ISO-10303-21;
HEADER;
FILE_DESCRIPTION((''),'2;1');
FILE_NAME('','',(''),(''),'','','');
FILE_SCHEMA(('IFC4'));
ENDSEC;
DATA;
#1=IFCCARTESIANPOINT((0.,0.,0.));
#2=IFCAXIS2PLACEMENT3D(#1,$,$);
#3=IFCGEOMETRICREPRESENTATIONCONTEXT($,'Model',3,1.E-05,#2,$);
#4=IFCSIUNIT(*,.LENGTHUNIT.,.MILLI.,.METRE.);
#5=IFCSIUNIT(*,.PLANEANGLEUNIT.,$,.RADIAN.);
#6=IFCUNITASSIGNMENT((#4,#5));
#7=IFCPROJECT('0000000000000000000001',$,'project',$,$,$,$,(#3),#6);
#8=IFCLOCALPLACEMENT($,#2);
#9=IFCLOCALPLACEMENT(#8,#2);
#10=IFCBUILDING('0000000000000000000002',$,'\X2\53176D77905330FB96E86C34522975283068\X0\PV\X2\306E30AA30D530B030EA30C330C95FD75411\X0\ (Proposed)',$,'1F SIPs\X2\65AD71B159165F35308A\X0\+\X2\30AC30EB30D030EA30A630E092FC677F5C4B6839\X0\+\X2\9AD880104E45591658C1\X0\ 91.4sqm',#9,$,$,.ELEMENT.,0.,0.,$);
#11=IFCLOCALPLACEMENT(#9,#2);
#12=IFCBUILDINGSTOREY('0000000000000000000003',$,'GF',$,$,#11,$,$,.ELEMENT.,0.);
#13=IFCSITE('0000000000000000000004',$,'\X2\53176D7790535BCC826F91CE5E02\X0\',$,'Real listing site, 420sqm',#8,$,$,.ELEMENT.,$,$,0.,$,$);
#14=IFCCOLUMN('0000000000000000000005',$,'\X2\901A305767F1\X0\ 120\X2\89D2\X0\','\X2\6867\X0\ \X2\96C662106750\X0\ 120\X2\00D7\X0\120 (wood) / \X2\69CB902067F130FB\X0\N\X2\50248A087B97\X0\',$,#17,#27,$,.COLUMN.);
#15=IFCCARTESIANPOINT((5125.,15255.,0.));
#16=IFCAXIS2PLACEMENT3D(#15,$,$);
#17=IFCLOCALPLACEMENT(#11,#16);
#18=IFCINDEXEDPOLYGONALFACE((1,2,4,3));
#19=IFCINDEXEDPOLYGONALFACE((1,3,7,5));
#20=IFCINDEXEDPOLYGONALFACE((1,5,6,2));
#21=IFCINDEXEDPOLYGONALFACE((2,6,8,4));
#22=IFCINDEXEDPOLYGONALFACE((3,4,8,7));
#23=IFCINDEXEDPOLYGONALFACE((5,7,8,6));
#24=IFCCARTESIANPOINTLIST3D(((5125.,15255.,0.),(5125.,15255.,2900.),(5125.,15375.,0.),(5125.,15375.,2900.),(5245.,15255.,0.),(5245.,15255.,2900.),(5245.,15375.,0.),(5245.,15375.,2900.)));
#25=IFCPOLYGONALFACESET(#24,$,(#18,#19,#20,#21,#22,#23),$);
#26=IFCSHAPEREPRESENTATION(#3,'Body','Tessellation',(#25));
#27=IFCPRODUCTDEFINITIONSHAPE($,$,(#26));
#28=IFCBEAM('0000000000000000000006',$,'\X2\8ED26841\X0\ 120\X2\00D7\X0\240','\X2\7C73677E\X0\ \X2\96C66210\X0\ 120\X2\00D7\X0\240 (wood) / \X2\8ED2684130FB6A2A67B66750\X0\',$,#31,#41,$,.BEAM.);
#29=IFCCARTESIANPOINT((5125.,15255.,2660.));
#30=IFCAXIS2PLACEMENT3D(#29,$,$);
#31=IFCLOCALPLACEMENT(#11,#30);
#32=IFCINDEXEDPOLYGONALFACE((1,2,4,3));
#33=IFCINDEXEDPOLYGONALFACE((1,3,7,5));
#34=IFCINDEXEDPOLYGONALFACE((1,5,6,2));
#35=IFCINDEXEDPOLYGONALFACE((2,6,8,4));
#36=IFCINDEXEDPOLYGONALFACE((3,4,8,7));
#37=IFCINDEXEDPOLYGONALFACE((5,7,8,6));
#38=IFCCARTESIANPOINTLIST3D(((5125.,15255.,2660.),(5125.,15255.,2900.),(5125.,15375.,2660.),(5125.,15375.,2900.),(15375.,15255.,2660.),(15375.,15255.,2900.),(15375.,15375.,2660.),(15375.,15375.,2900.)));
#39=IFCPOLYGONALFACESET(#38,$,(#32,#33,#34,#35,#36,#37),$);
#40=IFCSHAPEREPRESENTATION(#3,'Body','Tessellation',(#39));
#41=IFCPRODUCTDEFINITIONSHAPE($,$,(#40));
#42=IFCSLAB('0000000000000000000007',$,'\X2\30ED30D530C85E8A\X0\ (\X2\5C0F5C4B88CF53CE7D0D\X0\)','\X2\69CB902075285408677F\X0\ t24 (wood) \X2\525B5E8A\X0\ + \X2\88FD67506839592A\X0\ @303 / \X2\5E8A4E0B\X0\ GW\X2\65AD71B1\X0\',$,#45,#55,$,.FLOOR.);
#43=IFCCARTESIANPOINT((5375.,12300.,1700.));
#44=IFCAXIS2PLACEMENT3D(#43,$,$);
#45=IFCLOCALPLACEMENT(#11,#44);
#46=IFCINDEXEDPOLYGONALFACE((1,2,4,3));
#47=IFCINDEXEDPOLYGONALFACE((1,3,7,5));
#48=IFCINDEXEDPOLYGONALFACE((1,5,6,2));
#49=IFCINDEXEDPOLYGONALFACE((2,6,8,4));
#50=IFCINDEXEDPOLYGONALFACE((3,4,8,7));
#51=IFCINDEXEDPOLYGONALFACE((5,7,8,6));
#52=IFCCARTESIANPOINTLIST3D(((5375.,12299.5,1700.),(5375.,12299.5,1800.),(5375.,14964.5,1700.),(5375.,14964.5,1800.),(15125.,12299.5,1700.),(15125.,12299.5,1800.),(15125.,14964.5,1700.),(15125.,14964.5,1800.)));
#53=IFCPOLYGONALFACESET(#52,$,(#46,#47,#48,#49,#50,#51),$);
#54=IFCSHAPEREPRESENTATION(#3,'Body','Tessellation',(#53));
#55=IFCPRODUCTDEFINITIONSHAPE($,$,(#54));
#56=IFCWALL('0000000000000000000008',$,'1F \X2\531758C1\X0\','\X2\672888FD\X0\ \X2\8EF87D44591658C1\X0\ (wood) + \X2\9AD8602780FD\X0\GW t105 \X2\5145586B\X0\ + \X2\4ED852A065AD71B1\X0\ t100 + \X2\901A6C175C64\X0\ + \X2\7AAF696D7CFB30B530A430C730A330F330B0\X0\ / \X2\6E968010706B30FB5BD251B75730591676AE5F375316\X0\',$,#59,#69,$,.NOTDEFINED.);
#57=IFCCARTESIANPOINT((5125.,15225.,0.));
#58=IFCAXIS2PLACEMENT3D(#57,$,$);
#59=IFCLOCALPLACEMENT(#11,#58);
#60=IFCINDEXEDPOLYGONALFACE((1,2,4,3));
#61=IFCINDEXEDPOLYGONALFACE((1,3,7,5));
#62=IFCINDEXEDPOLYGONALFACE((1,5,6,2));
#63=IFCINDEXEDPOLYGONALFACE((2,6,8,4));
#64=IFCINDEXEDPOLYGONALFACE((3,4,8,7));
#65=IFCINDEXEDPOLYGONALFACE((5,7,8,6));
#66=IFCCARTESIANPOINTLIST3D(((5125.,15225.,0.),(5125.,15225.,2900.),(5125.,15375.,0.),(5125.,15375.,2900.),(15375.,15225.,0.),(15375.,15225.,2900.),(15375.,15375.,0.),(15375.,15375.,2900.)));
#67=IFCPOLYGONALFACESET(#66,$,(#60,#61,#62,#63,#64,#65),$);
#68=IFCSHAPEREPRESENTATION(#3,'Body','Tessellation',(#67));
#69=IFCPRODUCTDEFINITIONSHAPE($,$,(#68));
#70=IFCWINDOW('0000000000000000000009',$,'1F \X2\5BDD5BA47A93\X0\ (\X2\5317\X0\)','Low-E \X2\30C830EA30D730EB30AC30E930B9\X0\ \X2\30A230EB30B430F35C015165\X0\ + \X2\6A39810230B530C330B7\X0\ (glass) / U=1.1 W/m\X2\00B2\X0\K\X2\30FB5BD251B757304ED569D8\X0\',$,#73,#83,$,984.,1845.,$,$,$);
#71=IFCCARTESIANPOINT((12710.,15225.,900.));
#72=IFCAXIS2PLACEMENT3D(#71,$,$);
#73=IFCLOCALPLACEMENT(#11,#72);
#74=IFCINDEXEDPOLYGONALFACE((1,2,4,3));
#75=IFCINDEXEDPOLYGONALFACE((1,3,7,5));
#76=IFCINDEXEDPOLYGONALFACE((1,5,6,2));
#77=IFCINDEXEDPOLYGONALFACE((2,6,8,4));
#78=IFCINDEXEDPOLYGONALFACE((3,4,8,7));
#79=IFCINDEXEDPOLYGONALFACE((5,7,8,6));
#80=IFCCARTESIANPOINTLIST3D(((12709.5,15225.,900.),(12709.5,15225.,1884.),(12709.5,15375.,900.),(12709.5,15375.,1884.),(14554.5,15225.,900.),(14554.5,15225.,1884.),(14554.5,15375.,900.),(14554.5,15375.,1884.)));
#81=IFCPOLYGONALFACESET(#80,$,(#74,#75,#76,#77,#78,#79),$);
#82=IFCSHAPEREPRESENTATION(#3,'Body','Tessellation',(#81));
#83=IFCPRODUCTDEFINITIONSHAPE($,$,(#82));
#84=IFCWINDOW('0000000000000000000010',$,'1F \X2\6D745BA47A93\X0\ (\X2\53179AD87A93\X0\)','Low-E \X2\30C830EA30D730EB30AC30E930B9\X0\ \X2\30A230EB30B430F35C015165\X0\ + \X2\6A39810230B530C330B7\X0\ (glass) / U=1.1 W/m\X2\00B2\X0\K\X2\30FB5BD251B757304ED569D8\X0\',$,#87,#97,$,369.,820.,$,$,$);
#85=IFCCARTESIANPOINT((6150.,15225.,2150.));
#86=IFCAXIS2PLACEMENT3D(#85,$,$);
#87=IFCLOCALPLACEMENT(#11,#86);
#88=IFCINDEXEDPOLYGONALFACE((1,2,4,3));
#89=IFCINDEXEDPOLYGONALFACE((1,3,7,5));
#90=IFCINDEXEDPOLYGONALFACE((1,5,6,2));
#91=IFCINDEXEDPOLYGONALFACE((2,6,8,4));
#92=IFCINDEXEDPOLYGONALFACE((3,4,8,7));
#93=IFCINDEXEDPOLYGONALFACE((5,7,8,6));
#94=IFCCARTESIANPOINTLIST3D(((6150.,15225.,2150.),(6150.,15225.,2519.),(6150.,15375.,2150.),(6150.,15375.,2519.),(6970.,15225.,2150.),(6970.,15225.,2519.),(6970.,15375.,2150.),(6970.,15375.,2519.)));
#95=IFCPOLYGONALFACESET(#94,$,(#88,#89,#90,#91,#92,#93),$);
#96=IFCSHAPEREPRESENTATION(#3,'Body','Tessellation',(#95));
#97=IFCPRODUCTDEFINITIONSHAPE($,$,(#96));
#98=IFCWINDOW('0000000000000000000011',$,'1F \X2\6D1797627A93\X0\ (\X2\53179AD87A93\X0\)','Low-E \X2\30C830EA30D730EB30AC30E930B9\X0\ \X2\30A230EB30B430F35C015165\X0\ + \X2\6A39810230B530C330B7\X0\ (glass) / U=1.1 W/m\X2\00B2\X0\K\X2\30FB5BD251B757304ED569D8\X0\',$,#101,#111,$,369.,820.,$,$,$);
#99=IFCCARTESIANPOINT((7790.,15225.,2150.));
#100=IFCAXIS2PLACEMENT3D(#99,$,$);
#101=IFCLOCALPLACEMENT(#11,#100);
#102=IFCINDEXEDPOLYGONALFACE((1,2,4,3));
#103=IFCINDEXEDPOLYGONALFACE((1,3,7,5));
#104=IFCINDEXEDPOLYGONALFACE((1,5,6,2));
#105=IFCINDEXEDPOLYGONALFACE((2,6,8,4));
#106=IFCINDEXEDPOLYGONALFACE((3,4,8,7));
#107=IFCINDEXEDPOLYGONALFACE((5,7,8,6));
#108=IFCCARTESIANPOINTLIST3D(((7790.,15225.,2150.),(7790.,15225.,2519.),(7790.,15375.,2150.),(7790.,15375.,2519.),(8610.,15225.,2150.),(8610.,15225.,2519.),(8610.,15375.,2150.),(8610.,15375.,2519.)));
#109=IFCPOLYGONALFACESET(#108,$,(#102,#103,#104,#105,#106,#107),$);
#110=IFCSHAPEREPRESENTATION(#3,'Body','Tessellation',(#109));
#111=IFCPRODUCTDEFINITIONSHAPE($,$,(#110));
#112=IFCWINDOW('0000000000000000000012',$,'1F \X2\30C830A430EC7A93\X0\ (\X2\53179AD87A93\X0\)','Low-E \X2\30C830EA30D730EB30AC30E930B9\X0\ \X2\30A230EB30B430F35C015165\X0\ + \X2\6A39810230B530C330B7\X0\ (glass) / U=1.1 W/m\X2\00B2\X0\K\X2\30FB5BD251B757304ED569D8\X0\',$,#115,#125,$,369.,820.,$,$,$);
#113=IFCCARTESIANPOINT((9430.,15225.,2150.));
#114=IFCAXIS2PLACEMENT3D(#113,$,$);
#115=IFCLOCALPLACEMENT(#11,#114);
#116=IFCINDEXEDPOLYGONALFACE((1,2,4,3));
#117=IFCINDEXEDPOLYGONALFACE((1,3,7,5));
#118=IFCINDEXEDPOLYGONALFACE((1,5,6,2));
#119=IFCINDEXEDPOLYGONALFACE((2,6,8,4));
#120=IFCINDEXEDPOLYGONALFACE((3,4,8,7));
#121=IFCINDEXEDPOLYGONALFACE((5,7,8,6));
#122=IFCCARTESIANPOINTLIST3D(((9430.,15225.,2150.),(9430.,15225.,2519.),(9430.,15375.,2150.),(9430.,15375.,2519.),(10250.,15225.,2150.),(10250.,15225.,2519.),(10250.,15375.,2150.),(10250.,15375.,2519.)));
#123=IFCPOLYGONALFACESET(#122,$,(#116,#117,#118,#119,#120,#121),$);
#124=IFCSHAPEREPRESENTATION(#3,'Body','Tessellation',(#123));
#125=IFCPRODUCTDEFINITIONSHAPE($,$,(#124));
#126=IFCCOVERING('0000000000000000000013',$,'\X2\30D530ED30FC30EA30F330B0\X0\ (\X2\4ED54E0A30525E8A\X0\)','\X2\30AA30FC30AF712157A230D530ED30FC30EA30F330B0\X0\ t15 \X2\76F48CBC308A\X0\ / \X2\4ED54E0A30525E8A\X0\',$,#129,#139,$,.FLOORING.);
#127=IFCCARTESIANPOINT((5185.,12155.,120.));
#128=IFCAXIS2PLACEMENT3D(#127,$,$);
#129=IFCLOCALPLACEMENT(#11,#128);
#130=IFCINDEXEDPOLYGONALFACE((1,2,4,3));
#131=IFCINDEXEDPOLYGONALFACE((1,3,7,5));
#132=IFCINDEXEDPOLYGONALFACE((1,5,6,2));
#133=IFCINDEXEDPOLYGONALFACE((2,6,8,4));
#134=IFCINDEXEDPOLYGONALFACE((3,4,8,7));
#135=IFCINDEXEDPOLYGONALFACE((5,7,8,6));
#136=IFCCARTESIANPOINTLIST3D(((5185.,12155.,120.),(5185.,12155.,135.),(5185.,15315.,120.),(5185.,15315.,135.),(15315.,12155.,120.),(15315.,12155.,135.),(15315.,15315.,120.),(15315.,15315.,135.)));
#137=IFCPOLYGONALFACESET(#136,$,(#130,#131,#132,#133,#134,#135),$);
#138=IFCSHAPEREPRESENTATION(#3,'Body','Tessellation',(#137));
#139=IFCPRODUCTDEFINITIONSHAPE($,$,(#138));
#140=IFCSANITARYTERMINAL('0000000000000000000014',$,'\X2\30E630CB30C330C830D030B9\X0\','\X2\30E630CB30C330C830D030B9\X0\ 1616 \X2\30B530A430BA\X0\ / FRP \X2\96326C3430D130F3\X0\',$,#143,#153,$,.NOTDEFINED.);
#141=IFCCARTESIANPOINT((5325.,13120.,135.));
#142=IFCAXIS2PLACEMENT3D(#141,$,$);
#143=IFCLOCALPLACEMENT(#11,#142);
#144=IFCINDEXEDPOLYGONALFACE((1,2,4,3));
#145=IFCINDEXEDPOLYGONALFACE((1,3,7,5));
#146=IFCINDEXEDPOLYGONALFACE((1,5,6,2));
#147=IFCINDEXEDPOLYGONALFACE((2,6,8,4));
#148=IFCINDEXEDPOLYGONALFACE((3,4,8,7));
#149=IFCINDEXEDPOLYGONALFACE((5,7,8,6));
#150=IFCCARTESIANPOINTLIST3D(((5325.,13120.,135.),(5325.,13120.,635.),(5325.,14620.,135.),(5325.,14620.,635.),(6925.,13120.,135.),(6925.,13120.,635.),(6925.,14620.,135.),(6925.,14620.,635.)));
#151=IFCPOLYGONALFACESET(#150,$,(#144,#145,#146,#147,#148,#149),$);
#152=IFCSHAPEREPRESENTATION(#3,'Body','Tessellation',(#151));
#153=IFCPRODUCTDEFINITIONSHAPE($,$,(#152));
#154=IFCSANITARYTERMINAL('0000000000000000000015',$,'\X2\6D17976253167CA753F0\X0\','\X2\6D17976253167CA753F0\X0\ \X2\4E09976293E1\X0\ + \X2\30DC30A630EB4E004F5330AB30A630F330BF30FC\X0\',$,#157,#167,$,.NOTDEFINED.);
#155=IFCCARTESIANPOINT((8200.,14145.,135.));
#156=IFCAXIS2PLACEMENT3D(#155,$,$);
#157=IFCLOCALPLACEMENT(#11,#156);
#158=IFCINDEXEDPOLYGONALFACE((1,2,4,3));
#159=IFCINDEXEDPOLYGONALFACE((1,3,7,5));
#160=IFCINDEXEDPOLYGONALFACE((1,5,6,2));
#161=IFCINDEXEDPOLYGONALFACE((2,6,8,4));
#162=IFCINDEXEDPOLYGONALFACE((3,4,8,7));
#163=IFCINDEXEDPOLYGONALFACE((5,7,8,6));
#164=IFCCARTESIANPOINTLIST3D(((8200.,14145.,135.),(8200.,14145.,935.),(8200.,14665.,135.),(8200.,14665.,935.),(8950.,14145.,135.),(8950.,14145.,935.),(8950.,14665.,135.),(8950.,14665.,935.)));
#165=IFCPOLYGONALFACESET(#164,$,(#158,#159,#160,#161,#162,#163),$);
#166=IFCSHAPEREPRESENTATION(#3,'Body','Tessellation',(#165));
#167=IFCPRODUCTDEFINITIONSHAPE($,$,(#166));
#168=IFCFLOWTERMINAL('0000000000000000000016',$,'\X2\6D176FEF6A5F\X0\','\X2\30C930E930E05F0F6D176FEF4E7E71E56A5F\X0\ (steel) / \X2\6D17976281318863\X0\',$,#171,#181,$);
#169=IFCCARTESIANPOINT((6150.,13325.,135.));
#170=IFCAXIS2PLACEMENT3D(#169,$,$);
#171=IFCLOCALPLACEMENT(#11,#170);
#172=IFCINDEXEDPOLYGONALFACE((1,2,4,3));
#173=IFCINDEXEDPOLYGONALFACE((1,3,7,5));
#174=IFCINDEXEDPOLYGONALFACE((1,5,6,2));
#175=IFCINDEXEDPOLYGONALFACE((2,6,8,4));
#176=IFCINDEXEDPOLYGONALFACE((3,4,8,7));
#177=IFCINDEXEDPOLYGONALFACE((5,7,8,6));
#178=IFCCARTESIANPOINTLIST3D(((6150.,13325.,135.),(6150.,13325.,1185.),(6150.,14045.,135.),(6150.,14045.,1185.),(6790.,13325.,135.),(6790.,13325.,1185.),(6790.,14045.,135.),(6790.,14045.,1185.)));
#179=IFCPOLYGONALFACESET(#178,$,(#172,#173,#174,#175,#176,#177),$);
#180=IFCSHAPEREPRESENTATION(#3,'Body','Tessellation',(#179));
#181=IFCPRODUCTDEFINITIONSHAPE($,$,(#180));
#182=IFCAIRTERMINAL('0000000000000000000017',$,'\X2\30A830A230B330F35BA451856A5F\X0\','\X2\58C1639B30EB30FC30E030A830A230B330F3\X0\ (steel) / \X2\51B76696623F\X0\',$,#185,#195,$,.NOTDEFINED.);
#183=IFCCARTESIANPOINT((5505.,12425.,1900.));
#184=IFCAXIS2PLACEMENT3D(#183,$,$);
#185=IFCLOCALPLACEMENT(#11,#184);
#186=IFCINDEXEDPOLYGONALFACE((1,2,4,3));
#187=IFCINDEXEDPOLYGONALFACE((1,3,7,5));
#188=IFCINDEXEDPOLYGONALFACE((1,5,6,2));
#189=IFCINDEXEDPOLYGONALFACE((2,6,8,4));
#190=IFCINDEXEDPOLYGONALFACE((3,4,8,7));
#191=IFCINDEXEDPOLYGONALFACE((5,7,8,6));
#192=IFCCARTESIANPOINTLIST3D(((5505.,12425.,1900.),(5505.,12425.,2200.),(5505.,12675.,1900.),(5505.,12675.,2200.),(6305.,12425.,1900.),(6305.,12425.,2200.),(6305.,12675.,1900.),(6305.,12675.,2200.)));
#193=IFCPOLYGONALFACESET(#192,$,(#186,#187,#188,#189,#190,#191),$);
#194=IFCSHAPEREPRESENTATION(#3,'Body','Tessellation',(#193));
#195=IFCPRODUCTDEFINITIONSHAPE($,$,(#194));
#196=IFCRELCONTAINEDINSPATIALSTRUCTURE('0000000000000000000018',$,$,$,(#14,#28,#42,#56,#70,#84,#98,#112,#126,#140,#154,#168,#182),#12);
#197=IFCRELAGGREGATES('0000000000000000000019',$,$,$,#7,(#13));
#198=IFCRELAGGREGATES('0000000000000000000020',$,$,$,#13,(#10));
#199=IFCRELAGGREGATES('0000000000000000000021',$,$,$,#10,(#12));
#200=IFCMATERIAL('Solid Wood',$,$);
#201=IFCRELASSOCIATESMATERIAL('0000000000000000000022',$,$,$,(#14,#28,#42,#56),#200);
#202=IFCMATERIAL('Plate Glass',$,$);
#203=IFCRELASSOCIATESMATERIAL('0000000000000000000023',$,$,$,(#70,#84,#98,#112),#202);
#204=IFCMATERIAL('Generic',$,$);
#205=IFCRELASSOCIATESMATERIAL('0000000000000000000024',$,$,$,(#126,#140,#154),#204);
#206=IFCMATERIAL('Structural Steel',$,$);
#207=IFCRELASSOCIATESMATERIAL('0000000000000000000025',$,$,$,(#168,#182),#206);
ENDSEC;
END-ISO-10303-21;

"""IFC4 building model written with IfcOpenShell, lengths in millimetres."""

from ifc_helpers import new_model, si_unit, frame, frame_2d, origin, place, context, project, spatial, rectangle, extrude, material, element, fill, save


model = new_model("IFC4")

# Units and contexts
model_context = context("Model", 3, precision=1e-05, world=origin())
ifc_project = project(units=[si_unit("LENGTHUNIT", "METRE", prefix="MILLI"), si_unit("PLANEANGLEUNIT", "RADIAN")], contexts=[model_context])

# Site, building, storey
site_placement = place(None, origin())
site = spatial("IfcSite", under=ifc_project, at=site_placement, Name="北海道富良野市", ObjectType="Real listing site, 420sqm", CompositionType="ELEMENT", RefElevation=0.0)
building_placement = place(site_placement, origin())
building = spatial("IfcBuilding", under=site, at=building_placement, Name="北海道・雨水利用とPVのオフグリッド志向 (Proposed)", ObjectType="1F SIPs断熱外張り+ガルバリウム鋼板屋根+高耐久外壁 91.4sqm", CompositionType="ELEMENT", ElevationOfRefHeight=0.0, ElevationOfTerrain=0.0)
storey_placement = place(building_placement, origin())
storey = spatial("IfcBuildingStorey", under=building, at=storey_placement, Name="GF", CompositionType="ELEMENT", Elevation=0.0)

# Column
ifc_material_1 = material(Name="Solid Wood")
column_1_placement = place(storey_placement, frame((5125.0, 15255.0, 0.0)))
element("IfcColumn", 1, at=column_1_placement, inside=storey, material=ifc_material_1, Name="通し柱 120角", Description="桧 集成材 120×120 (wood) / 構造柱・N値計算", PredefinedType="COLUMN", context=model_context, shape_type="SweptSolid", body=[
    extrude(rectangle(XDim=120.0, YDim=120.0, at=frame_2d((60.0, 60.0))), frame((5125.0, 15255.0, 0.0)), (0.0, 0.0, 1.0), 2900.0),
])

# Beam
beam_1_placement = place(storey_placement, frame((5125.0, 15255.0, 2660.0)))
element("IfcBeam", 2, at=beam_1_placement, inside=storey, material=ifc_material_1, Name="軒桁 120×240", Description="米松 集成 120×240 (wood) / 軒桁・横架材", PredefinedType="BEAM", context=model_context, shape_type="SweptSolid", body=[
    extrude(rectangle(XDim=10250.0, YDim=120.0, at=frame_2d((5125.0, 60.0))), frame((5125.0, 15255.0, 2660.0)), (0.0, 0.0, 1.0), 240.0),
])

# Slab
slab_placement = place(storey_placement, frame((5375.0, 12300.0, 1700.0)))
element("IfcSlab", 3, at=slab_placement, inside=storey, material=ifc_material_1, Name="ロフト床 (小屋裏収納)", Description="構造用合板 t24 (wood) 剛床 + 製材根太 @303 / 床下 GW断熱", PredefinedType="FLOOR", context=model_context, shape_type="SweptSolid", body=[
    extrude(rectangle(XDim=9750.0, YDim=2665.0, at=frame_2d((4875.0, 1332.0))), frame((5375.0, 12300.0, 1700.0)), (0.0, 0.0, 1.0), 100.0),
])

# Wall, openings, windows
wall_1_placement = place(storey_placement, frame((5125.0, 15225.0, 0.0)))
wall_1 = element("IfcWall", 4, at=wall_1_placement, inside=storey, material=ifc_material_1, Name="1F 北壁", Description="木製 軸組外壁 (wood) + 高性能GW t105 充填 + 付加断熱 t100 + 通気層 + 窯業系サイディング / 準耐火・寒冷地外皮強化", PredefinedType="NOTDEFINED", context=model_context, shape_type="SweptSolid", body=[
    extrude(rectangle(XDim=10250.0, YDim=150.0, at=frame_2d((5125.0, 75.0))), frame((5125.0, 15225.0, 0.0)), (0.0, 0.0, 1.0), 2900.0),
])
opening_1_placement = place(storey_placement, frame((12710.0, 15225.0, 900.0)))
opening_1 = element("IfcOpeningElement", 5, at=opening_1_placement, cuts=wall_1, PredefinedType="NOTDEFINED", context=model_context, shape_type="SweptSolid", body=[
    extrude(rectangle(XDim=1845.0, YDim=150.0, at=frame_2d((922.0, 75.0))), frame((12710.0, 15225.0, 900.0)), (0.0, 0.0, 1.0), 984.0),
])
opening_2_placement = place(storey_placement, frame((6150.0, 15225.0, 2150.0)))
opening_2 = element("IfcOpeningElement", 6, at=opening_2_placement, cuts=wall_1, PredefinedType="NOTDEFINED", context=model_context, shape_type="SweptSolid", body=[
    extrude(rectangle(XDim=820.0, YDim=150.0, at=frame_2d((410.0, 75.0))), frame((6150.0, 15225.0, 2150.0)), (0.0, 0.0, 1.0), 369.0),
])
opening_3_placement = place(storey_placement, frame((7790.0, 15225.0, 2150.0)))
opening_3 = element("IfcOpeningElement", 7, at=opening_3_placement, cuts=wall_1, PredefinedType="NOTDEFINED", context=model_context, shape_type="SweptSolid", body=[
    extrude(rectangle(XDim=820.0, YDim=150.0, at=frame_2d((410.0, 75.0))), frame((7790.0, 15225.0, 2150.0)), (0.0, 0.0, 1.0), 369.0),
])
opening_4_placement = place(storey_placement, frame((9430.0, 15225.0, 2150.0)))
opening_4 = element("IfcOpeningElement", 8, at=opening_4_placement, cuts=wall_1, PredefinedType="NOTDEFINED", context=model_context, shape_type="SweptSolid", body=[
    extrude(rectangle(XDim=820.0, YDim=150.0, at=frame_2d((410.0, 75.0))), frame((9430.0, 15225.0, 2150.0)), (0.0, 0.0, 1.0), 369.0),
])
ifc_material_2 = material(Name="Plate Glass")
window_1_placement = place(storey_placement, frame((12710.0, 15225.0, 900.0)))
window_1 = element("IfcWindow", 9, at=window_1_placement, inside=storey, material=ifc_material_2, Name="1F 寝室窓 (北)", Description="Low-E トリプルガラス アルゴン封入 + 樹脂サッシ (glass) / U=1.1 W/m²K・寒冷地仕様", OverallHeight=984.0, OverallWidth=1845.0, context=model_context, shape_type="SweptSolid", body=[
    extrude(rectangle(XDim=1845.0, YDim=150.0, at=frame_2d((922.0, 75.0))), frame((12710.0, 15225.0, 900.0)), (0.0, 0.0, 1.0), 984.0),
])
fill(opening_1, window_1)
window_2_placement = place(storey_placement, frame((6150.0, 15225.0, 2150.0)))
window_2 = element("IfcWindow", 10, at=window_2_placement, inside=storey, material=ifc_material_2, Name="1F 浴室窓 (北高窓)", Description="Low-E トリプルガラス アルゴン封入 + 樹脂サッシ (glass) / U=1.1 W/m²K・寒冷地仕様", OverallHeight=369.0, OverallWidth=820.0, context=model_context, shape_type="SweptSolid", body=[
    extrude(rectangle(XDim=820.0, YDim=150.0, at=frame_2d((410.0, 75.0))), frame((6150.0, 15225.0, 2150.0)), (0.0, 0.0, 1.0), 369.0),
])
fill(opening_2, window_2)
window_3_placement = place(storey_placement, frame((7790.0, 15225.0, 2150.0)))
window_3 = element("IfcWindow", 11, at=window_3_placement, inside=storey, material=ifc_material_2, Name="1F 洗面窓 (北高窓)", Description="Low-E トリプルガラス アルゴン封入 + 樹脂サッシ (glass) / U=1.1 W/m²K・寒冷地仕様", OverallHeight=369.0, OverallWidth=820.0, context=model_context, shape_type="SweptSolid", body=[
    extrude(rectangle(XDim=820.0, YDim=150.0, at=frame_2d((410.0, 75.0))), frame((7790.0, 15225.0, 2150.0)), (0.0, 0.0, 1.0), 369.0),
])
fill(opening_3, window_3)
window_4_placement = place(storey_placement, frame((9430.0, 15225.0, 2150.0)))
window_4 = element("IfcWindow", 12, at=window_4_placement, inside=storey, material=ifc_material_2, Name="1F トイレ窓 (北高窓)", Description="Low-E トリプルガラス アルゴン封入 + 樹脂サッシ (glass) / U=1.1 W/m²K・寒冷地仕様", OverallHeight=369.0, OverallWidth=820.0, context=model_context, shape_type="SweptSolid", body=[
    extrude(rectangle(XDim=820.0, YDim=150.0, at=frame_2d((410.0, 75.0))), frame((9430.0, 15225.0, 2150.0)), (0.0, 0.0, 1.0), 369.0),
])
fill(opening_4, window_4)

# Covering
ifc_material_3 = material(Name="Generic")
covering_placement = place(storey_placement, frame((5185.0, 12155.0, 120.0)))
element("IfcCovering", 13, at=covering_placement, inside=storey, material=ifc_material_3, Name="フローリング (仕上げ床)", Description="オーク無垢フローリング t15 直貼り / 仕上げ床", PredefinedType="FLOORING", context=model_context, shape_type="SweptSolid", body=[
    extrude(rectangle(XDim=10130.0, YDim=3160.0, at=frame_2d((5065.0, 1580.0))), frame((5185.0, 12155.0, 120.0)), (0.0, 0.0, 1.0), 15.0),
])

# Sanitary terminals
sanitary_terminal_1_placement = place(storey_placement, frame((5325.0, 13120.0, 135.0)))
element("IfcSanitaryTerminal", 14, at=sanitary_terminal_1_placement, inside=storey, material=ifc_material_3, Name="ユニットバス", Description="ユニットバス 1616 サイズ / FRP 防水パン", PredefinedType="NOTDEFINED", context=model_context, shape_type="SweptSolid", body=[
    extrude(rectangle(XDim=1600.0, YDim=1500.0, at=frame_2d((800.0, 750.0))), frame((5325.0, 13120.0, 135.0)), (0.0, 0.0, 1.0), 500.0),
])
sanitary_terminal_2_placement = place(storey_placement, frame((8200.0, 14145.0, 135.0)))
element("IfcSanitaryTerminal", 15, at=sanitary_terminal_2_placement, inside=storey, material=ifc_material_3, Name="洗面化粧台", Description="洗面化粧台 三面鏡 + ボウル一体カウンター", PredefinedType="NOTDEFINED", context=model_context, shape_type="SweptSolid", body=[
    extrude(rectangle(XDim=750.0, YDim=520.0, at=frame_2d((375.0, 260.0))), frame((8200.0, 14145.0, 135.0)), (0.0, 0.0, 1.0), 800.0),
])

# Flow terminal
ifc_material_4 = material(Name="Structural Steel")
flow_terminal_placement = place(storey_placement, frame((6150.0, 13325.0, 135.0)))
element("IfcFlowTerminal", 16, at=flow_terminal_placement, inside=storey, material=ifc_material_4, Name="洗濯機", Description="ドラム式洗濯乾燥機 (steel) / 洗面脱衣", context=model_context, shape_type="SweptSolid", body=[
    extrude(rectangle(XDim=640.0, YDim=720.0, at=frame_2d((320.0, 360.0))), frame((6150.0, 13325.0, 135.0)), (0.0, 0.0, 1.0), 1050.0),
])

# Air terminal
air_terminal_placement = place(storey_placement, frame((5505.0, 12425.0, 1900.0)))
element("IfcAirTerminal", 17, at=air_terminal_placement, inside=storey, material=ifc_material_4, Name="エアコン室内機", Description="壁掛ルームエアコン (steel) / 冷暖房", PredefinedType="NOTDEFINED", context=model_context, shape_type="SweptSolid", body=[
    extrude(rectangle(XDim=800.0, YDim=250.0, at=frame_2d((400.0, 125.0))), frame((5505.0, 12425.0, 1900.0)), (0.0, 0.0, 1.0), 300.0),
])

save(model, "model.ifc")
